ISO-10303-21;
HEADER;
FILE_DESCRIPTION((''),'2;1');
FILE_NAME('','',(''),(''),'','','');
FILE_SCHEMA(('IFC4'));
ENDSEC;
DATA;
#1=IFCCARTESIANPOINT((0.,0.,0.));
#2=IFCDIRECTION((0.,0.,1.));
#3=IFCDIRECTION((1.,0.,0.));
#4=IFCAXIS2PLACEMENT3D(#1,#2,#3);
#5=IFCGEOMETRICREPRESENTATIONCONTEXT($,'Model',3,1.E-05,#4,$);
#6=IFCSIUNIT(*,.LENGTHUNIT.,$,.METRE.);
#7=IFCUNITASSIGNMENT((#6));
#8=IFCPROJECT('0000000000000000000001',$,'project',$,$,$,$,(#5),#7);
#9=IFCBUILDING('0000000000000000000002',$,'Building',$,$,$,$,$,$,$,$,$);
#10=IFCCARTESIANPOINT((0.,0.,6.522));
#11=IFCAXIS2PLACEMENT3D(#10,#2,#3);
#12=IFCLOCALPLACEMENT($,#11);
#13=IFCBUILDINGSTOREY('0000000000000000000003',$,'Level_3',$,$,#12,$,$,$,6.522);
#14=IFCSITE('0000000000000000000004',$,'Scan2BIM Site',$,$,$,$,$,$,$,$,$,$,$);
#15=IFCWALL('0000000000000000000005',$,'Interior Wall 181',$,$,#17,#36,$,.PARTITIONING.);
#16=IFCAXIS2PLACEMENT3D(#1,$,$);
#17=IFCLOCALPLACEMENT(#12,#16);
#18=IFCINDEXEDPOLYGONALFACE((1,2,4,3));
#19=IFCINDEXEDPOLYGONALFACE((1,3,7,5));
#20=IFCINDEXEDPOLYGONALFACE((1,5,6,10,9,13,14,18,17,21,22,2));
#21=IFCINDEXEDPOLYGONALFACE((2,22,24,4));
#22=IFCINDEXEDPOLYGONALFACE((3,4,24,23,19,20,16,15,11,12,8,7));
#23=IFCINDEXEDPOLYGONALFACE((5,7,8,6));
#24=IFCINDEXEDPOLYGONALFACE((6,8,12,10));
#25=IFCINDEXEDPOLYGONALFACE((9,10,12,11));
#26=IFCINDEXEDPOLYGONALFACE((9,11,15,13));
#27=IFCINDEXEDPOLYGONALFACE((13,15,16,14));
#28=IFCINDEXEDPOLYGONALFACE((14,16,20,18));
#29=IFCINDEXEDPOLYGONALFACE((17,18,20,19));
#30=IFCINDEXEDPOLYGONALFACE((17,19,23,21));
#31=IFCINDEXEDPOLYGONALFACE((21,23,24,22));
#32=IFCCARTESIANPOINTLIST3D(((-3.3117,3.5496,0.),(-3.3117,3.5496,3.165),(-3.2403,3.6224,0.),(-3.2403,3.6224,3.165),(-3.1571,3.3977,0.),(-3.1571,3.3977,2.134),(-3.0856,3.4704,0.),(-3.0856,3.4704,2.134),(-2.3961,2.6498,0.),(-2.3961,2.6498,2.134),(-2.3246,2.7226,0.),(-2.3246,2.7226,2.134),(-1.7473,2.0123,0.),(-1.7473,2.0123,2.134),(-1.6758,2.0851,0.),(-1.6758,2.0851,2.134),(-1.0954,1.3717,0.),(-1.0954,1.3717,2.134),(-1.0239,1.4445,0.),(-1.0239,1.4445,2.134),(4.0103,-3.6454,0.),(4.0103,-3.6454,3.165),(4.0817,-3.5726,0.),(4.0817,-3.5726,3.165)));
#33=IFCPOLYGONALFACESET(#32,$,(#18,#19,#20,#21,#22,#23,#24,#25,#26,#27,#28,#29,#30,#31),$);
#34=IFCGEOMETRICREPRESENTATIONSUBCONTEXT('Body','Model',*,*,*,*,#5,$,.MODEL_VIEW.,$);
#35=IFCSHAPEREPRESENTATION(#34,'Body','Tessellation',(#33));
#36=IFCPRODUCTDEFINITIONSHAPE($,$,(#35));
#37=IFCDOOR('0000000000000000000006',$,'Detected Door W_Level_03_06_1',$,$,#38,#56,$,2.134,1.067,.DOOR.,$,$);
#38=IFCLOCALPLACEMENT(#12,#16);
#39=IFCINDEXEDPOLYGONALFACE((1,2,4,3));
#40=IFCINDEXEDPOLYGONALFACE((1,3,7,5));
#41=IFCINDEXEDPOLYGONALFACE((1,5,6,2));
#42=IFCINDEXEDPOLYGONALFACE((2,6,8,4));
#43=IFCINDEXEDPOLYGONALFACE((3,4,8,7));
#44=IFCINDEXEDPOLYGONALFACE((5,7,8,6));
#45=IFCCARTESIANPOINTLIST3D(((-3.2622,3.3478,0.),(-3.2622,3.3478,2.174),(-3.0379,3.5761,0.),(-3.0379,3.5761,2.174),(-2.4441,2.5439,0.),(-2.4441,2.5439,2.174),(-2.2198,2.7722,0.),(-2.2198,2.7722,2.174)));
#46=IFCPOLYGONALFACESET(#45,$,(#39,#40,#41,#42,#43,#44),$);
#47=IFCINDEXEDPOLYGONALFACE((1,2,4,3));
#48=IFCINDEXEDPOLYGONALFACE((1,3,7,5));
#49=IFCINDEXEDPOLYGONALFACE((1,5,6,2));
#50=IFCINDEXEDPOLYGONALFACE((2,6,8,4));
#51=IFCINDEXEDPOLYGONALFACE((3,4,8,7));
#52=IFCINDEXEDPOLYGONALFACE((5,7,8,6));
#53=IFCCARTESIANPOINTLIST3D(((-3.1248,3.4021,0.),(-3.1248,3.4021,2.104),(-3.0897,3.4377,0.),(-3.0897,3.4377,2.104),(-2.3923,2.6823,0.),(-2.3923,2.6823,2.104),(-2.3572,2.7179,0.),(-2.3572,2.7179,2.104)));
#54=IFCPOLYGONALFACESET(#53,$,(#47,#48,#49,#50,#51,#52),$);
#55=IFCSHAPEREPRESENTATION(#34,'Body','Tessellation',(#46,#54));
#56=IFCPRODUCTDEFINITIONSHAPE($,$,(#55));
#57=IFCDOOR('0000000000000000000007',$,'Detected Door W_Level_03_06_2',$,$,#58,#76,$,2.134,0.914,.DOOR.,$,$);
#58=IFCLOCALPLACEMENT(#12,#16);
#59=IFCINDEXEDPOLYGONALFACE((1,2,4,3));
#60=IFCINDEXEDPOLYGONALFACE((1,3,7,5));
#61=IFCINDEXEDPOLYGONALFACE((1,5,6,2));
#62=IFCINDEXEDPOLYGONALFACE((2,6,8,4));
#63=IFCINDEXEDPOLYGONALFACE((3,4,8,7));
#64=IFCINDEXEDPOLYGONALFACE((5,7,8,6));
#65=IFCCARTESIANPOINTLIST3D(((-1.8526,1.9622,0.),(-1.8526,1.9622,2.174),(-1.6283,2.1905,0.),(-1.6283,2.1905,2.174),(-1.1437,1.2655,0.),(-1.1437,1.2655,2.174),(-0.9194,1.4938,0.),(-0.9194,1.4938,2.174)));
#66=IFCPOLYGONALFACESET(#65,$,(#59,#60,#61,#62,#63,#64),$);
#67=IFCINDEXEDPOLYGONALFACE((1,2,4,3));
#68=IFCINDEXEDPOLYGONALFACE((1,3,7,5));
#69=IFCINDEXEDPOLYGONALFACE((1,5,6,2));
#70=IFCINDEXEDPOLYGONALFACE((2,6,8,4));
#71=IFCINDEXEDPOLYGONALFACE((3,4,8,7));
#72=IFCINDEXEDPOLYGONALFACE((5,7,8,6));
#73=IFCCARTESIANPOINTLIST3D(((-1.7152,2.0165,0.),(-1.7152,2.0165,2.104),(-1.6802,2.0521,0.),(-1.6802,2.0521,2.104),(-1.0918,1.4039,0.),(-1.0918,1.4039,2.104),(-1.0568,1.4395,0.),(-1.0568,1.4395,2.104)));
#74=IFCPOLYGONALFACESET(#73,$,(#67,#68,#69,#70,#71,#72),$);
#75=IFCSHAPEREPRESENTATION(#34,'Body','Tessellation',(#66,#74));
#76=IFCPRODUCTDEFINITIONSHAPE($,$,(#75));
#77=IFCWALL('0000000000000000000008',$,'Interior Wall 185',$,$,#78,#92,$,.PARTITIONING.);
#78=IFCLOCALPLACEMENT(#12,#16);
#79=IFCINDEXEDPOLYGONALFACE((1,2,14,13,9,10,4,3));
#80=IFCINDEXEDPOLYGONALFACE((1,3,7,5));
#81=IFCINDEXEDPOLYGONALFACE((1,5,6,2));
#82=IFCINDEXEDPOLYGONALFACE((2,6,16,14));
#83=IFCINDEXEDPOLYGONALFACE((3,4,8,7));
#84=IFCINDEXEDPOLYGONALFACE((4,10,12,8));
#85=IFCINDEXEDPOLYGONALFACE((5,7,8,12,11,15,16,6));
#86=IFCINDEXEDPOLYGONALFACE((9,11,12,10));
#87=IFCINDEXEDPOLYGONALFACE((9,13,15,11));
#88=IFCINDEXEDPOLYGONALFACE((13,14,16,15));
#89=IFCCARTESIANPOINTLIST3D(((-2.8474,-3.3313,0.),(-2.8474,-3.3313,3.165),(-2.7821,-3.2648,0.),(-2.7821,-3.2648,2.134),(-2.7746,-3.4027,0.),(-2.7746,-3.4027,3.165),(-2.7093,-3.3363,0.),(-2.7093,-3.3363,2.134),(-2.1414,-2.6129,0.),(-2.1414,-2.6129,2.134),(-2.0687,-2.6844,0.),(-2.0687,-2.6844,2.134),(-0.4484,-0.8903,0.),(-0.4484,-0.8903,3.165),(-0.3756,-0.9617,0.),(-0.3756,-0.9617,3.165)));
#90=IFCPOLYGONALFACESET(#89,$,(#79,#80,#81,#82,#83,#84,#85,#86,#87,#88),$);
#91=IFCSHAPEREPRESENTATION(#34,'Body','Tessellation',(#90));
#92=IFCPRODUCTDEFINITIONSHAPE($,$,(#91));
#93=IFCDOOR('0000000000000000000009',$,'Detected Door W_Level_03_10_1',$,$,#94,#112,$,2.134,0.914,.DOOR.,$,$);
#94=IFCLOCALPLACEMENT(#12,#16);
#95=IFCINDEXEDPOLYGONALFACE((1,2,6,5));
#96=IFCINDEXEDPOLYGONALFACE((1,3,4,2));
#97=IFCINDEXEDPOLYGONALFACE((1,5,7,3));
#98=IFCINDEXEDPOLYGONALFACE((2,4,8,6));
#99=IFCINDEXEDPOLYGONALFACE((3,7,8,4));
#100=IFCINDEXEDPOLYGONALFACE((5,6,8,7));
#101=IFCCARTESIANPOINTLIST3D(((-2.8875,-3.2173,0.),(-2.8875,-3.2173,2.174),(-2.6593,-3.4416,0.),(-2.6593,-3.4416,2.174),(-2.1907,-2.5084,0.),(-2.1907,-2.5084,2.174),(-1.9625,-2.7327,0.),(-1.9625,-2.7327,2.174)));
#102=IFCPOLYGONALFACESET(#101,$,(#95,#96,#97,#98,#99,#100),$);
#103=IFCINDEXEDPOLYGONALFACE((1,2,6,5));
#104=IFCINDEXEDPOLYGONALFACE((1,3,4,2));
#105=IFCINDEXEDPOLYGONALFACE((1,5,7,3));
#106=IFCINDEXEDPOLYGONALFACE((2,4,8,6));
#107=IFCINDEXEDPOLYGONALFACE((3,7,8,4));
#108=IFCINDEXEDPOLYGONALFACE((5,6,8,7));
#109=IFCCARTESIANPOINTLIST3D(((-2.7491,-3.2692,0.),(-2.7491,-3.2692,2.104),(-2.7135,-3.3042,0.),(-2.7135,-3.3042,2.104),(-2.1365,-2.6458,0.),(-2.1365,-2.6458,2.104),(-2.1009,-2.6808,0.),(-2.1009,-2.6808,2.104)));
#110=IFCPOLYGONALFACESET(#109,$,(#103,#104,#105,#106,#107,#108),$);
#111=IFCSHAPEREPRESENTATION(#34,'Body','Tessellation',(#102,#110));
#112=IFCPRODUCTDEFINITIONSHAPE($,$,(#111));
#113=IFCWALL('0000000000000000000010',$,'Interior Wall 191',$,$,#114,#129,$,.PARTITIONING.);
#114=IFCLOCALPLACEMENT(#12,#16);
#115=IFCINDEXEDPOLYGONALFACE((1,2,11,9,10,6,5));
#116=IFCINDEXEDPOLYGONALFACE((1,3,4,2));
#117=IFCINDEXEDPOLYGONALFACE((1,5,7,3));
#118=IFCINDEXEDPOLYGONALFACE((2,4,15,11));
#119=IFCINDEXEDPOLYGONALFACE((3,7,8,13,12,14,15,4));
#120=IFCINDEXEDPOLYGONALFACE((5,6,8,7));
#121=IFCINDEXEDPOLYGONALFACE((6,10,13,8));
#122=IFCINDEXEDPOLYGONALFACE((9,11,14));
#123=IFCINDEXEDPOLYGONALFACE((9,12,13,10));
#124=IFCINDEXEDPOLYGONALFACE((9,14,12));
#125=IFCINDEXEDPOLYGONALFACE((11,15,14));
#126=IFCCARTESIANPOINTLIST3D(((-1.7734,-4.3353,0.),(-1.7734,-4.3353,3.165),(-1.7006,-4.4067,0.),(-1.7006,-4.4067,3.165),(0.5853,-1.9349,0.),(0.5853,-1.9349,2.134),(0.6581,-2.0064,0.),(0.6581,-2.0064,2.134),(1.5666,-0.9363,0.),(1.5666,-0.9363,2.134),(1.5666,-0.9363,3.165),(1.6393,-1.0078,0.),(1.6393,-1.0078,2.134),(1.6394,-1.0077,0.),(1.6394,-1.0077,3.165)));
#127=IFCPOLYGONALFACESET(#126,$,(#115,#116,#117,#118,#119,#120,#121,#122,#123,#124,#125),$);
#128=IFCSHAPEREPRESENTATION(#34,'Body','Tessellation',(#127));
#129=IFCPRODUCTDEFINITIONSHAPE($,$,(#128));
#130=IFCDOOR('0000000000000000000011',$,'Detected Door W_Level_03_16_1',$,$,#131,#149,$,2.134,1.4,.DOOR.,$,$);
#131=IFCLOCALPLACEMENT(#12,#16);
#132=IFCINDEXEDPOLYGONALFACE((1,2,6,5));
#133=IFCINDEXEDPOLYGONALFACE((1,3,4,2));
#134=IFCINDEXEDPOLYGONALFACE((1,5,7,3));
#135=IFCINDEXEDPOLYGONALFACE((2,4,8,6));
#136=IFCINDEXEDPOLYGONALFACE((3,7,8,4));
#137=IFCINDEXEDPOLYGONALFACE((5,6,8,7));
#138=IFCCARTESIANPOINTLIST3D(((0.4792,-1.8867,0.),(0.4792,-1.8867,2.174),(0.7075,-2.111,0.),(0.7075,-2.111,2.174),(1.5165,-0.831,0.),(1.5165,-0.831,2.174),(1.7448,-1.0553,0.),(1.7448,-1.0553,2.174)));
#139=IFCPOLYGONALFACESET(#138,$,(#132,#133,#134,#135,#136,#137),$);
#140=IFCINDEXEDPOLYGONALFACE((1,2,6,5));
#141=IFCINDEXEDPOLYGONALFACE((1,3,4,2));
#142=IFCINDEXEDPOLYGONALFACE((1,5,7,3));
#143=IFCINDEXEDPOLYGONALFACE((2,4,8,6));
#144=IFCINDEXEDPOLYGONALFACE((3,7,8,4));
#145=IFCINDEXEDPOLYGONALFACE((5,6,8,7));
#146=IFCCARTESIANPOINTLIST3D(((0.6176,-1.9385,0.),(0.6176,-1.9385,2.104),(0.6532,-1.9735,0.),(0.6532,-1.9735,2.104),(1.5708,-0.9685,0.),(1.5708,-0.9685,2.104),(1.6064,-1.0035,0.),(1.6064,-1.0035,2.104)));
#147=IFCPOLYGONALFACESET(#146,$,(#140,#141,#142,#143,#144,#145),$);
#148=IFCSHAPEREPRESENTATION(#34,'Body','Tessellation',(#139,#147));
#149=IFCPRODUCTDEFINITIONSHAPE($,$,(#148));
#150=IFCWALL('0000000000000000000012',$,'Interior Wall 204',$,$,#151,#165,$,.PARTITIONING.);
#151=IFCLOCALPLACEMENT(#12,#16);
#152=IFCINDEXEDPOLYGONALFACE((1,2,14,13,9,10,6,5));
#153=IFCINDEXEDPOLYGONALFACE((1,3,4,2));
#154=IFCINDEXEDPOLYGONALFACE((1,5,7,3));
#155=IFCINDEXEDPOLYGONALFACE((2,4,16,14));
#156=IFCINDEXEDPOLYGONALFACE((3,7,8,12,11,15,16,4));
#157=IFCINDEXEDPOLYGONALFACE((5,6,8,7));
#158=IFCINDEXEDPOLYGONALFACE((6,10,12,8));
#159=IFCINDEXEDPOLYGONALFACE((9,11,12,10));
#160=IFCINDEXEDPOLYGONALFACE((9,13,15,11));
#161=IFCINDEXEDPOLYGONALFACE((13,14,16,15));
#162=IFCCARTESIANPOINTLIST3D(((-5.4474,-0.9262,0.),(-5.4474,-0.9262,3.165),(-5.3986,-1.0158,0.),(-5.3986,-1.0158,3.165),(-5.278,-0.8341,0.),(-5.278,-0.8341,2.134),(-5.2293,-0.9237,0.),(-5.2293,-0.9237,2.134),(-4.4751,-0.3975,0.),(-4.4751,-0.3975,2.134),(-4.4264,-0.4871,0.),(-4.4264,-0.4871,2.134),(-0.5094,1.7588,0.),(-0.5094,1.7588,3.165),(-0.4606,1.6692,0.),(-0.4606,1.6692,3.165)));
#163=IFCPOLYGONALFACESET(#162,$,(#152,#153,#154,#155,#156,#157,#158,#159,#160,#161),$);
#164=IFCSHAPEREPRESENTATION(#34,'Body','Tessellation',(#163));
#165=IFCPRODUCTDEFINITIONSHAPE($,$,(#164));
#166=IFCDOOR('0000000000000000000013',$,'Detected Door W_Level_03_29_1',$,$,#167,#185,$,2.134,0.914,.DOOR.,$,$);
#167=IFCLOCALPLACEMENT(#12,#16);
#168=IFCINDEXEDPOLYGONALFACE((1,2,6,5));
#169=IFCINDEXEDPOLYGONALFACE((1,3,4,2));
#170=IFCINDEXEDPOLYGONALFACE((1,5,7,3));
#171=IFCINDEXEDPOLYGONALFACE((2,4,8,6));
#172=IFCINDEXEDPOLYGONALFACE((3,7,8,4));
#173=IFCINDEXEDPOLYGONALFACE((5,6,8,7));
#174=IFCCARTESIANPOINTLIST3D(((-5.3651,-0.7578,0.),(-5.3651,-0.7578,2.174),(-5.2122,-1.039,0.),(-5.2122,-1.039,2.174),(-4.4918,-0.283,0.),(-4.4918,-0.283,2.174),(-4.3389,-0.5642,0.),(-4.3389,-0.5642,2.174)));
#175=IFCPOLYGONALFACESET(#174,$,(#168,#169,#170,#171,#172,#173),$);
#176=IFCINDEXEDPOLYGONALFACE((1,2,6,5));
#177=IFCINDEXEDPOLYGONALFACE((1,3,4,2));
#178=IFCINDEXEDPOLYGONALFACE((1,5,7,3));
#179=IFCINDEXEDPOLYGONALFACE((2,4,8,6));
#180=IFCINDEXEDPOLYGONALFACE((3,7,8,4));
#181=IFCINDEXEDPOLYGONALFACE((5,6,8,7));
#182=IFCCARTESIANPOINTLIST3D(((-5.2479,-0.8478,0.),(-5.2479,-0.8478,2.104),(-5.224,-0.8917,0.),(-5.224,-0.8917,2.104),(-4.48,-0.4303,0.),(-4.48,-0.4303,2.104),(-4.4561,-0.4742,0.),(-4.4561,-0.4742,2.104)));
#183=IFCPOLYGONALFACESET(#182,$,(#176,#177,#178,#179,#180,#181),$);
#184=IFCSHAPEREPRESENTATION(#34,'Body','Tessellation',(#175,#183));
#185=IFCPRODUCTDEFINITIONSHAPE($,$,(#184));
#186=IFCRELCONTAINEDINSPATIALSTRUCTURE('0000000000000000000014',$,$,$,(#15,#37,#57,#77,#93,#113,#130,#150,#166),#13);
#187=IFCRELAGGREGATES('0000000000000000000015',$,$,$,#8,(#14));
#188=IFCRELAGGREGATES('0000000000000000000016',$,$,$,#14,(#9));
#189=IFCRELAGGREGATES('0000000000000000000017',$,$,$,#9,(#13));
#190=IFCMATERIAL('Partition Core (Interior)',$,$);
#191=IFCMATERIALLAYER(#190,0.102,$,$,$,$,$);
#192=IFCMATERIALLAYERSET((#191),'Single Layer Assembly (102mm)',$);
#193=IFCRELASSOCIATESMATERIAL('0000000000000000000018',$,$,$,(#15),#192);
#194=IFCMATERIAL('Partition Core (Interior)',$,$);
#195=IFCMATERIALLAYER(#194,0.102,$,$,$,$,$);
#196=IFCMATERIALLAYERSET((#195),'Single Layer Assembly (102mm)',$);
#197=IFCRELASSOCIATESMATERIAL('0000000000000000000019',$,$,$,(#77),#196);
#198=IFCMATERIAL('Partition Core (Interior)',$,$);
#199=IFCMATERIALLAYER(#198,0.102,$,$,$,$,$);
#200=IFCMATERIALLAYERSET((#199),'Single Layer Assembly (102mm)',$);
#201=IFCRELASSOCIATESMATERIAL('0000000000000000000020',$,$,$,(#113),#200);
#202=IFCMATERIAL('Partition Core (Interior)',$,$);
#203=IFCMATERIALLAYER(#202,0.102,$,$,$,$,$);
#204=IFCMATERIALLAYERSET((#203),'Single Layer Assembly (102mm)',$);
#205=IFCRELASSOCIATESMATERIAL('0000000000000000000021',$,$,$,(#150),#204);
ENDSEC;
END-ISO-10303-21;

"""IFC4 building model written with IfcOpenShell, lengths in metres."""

from ifc_helpers import new_model, si_unit, frame, origin, origin_with_axes, place, context, subcontext, project, spatial, rectangle, extrude, material, layer, layer_set, element, fill, save


model = new_model("IFC4")

# Units and contexts
model_context = context("Model", 3, precision=1e-05, world=origin_with_axes())
body_context = subcontext(model_context, "Body", "Model", "MODEL_VIEW")
ifc_project = project(units=[si_unit("LENGTHUNIT", "METRE")], contexts=[model_context])

# Site, building, storey
site = spatial("IfcSite", under=ifc_project, Name="Scan2BIM Site")
building = spatial("IfcBuilding", under=site, Name="Building")
storey_placement = place(None, frame((0.0, 0.0, 6.522), z_axis=(0.0, 0.0, 1.0), x_axis=(1.0, 0.0, 0.0)))
storey = spatial("IfcBuildingStorey", under=building, at=storey_placement, Name="Level_3", Elevation=6.522)

# Wall, openings, doors
ifc_material_1 = material(Name="Partition Core (Interior)")
ifc_layer_1 = layer(ifc_material_1, 0.102)
ifc_layer_set_1 = layer_set([ifc_layer_1], Name="Single Layer Assembly (102mm)")
wall_1_placement = place(storey_placement, frame((0.385, -0.0115, 0.0), z_axis=(0.0, 0.0, 1.0), x_axis=(0.713266, -0.700894, 0.0)))
wall_1 = element("IfcWall", 1, at=wall_1_placement, inside=storey, material=ifc_layer_set_1, Name="Interior Wall 181", PredefinedType="PARTITIONING", context=body_context, shape_type="SweptSolid", body=[
    extrude(rectangle(XDim=10.2655, YDim=0.102), origin(), (0.0, 0.0, 1.0), 3.165),
])
opening_1_placement = place(None, frame((-2.741, 3.06, 6.522), z_axis=(0.0, 0.0, 1.0), x_axis=(0.713266, -0.700894, 0.0)))
opening_1 = element("IfcOpeningElement", 2, at=opening_1_placement, cuts=wall_1, PredefinedType="OPENING", context=body_context, shape_type="SweptSolid", body=[
    extrude(rectangle(XDim=1.067, YDim=0.202), origin(), (0.0, 0.0, 1.0), 2.134),
])
opening_2_placement = place(None, frame((-1.386, 1.728, 6.522), z_axis=(0.0, 0.0, 1.0), x_axis=(0.713266, -0.700894, 0.0)))
opening_2 = element("IfcOpeningElement", 3, at=opening_2_placement, cuts=wall_1, PredefinedType="OPENING", context=body_context, shape_type="SweptSolid", body=[
    extrude(rectangle(XDim=0.914, YDim=0.202), origin(), (0.0, 0.0, 1.0), 2.134),
])
door_1_placement = place(opening_1_placement, frame((0.0, 0.0, 0.0), z_axis=(0.0, 0.0, 1.0), x_axis=(1.0, 0.0, 0.0)))
door_1 = element("IfcDoor", 4, at=door_1_placement, inside=storey, Name="Detected Door W_Level_03_06_1", OverallHeight=2.134, OverallWidth=1.067, PredefinedType="DOOR", context=body_context, shape_type="SweptSolid", body=[
    extrude(rectangle(XDim=1.147, YDim=0.32), origin(), (0.0, 0.0, 1.0), 2.174),
    extrude(rectangle(XDim=1.027, YDim=0.05), origin(), (0.0, 0.0, 1.0), 2.104),
])
fill(opening_1, door_1)
door_2_placement = place(opening_2_placement, frame((0.0, 0.0, 0.0), z_axis=(0.0, 0.0, 1.0), x_axis=(1.0, 0.0, 0.0)))
door_2 = element("IfcDoor", 5, at=door_2_placement, inside=storey, Name="Detected Door W_Level_03_06_2", OverallHeight=2.134, OverallWidth=0.914, PredefinedType="DOOR", context=body_context, shape_type="SweptSolid", body=[
    extrude(rectangle(XDim=0.994, YDim=0.32), origin(), (0.0, 0.0, 1.0), 2.174),
    extrude(rectangle(XDim=0.874, YDim=0.05), origin(), (0.0, 0.0, 1.0), 2.104),
])
fill(opening_2, door_2)

# Walls, openings, doors
ifc_material_2 = material(Name="Partition Core (Interior)")
ifc_layer_2 = layer(ifc_material_2, 0.102)
ifc_layer_set_2 = layer_set([ifc_layer_2], Name="Single Layer Assembly (102mm)")
wall_2_placement = place(storey_placement, frame((-1.6115, -2.1465, 0.0), z_axis=(0.0, 0.0, 1.0), x_axis=(0.700944, 0.713216, 0.0)))
wall_2 = element("IfcWall", 6, at=wall_2_placement, inside=storey, material=ifc_layer_set_2, Name="Interior Wall 185", PredefinedType="PARTITIONING", context=body_context, shape_type="SweptSolid", body=[
    extrude(rectangle(XDim=3.4225, YDim=0.102), origin(), (0.0, 0.0, 1.0), 3.165),
])
opening_3_placement = place(None, frame((-2.425, -2.975, 6.522), z_axis=(0.0, 0.0, 1.0), x_axis=(0.700944, 0.713216, 0.0)))
opening_3 = element("IfcOpeningElement", 7, at=opening_3_placement, cuts=wall_2, PredefinedType="OPENING", context=body_context, shape_type="SweptSolid", body=[
    extrude(rectangle(XDim=0.914, YDim=0.202), origin(), (0.0, 0.0, 1.0), 2.134),
])
door_3_placement = place(opening_3_placement, frame((0.0, 0.0, 0.0), z_axis=(0.0, 0.0, 1.0), x_axis=(1.0, 0.0, 0.0)))
door_3 = element("IfcDoor", 8, at=door_3_placement, inside=storey, Name="Detected Door W_Level_03_10_1", OverallHeight=2.134, OverallWidth=0.914, PredefinedType="DOOR", context=body_context, shape_type="SweptSolid", body=[
    extrude(rectangle(XDim=0.994, YDim=0.32), origin(), (0.0, 0.0, 1.0), 2.174),
    extrude(rectangle(XDim=0.874, YDim=0.05), origin(), (0.0, 0.0, 1.0), 2.104),
])
fill(opening_3, door_3)
ifc_material_3 = material(Name="Partition Core (Interior)")
ifc_layer_3 = layer(ifc_material_3, 0.102)
ifc_layer_set_3 = layer_set([ifc_layer_3], Name="Single Layer Assembly (102mm)")
wall_3_placement = place(storey_placement, frame((-0.067, -2.6715, 0.0), z_axis=(0.0, 0.0, 1.0), x_axis=(-0.700889, -0.71327, 0.0)))
wall_3 = element("IfcWall", 9, at=wall_3_placement, inside=storey, material=ifc_layer_set_3, Name="Interior Wall 191", PredefinedType="PARTITIONING", context=body_context, shape_type="SweptSolid", body=[
    extrude(rectangle(XDim=4.7654, YDim=0.102), origin(), (0.0, 0.0, 1.0), 3.165),
])
opening_4_placement = place(None, frame((1.112, -1.471, 6.522), z_axis=(0.0, 0.0, 1.0), x_axis=(-0.700889, -0.71327, 0.0)))
opening_4 = element("IfcOpeningElement", 10, at=opening_4_placement, cuts=wall_3, PredefinedType="OPENING", context=body_context, shape_type="SweptSolid", body=[
    extrude(rectangle(XDim=1.4, YDim=0.202), origin(), (0.0, 0.0, 1.0), 2.134),
])
door_4_placement = place(opening_4_placement, frame((0.0, 0.0, 0.0), z_axis=(0.0, 0.0, 1.0), x_axis=(1.0, 0.0, 0.0)))
door_4 = element("IfcDoor", 11, at=door_4_placement, inside=storey, Name="Detected Door W_Level_03_16_1", OverallHeight=2.134, OverallWidth=1.4, PredefinedType="DOOR", context=body_context, shape_type="SweptSolid", body=[
    extrude(rectangle(XDim=1.48, YDim=0.32), origin(), (0.0, 0.0, 1.0), 2.174),
    extrude(rectangle(XDim=1.36, YDim=0.05), origin(), (0.0, 0.0, 1.0), 2.104),
])
fill(opening_4, door_4)
ifc_material_4 = material(Name="Partition Core (Interior)")
ifc_layer_4 = layer(ifc_material_4, 0.102)
ifc_layer_set_4 = layer_set([ifc_layer_4], Name="Single Layer Assembly (102mm)")
wall_4_placement = place(storey_placement, frame((-2.954, 0.3715, 0.0), z_axis=(0.0, 0.0, 1.0), x_axis=(0.878527, 0.477692, 0.0)))
wall_4 = element("IfcWall", 12, at=wall_4_placement, inside=storey, material=ifc_layer_set_4, Name="Interior Wall 204", PredefinedType="PARTITIONING", context=body_context, shape_type="SweptSolid", body=[
    extrude(rectangle(XDim=5.6208, YDim=0.102), origin(), (0.0, 0.0, 1.0), 3.165),
])
opening_5_placement = place(None, frame((-4.852, -0.661, 6.522), z_axis=(0.0, 0.0, 1.0), x_axis=(0.878527, 0.477692, 0.0)))
opening_5 = element("IfcOpeningElement", 13, at=opening_5_placement, cuts=wall_4, PredefinedType="OPENING", context=body_context, shape_type="SweptSolid", body=[
    extrude(rectangle(XDim=0.914, YDim=0.202), origin(), (0.0, 0.0, 1.0), 2.134),
])
door_5_placement = place(opening_5_placement, frame((0.0, 0.0, 0.0), z_axis=(0.0, 0.0, 1.0), x_axis=(1.0, 0.0, 0.0)))
door_5 = element("IfcDoor", 14, at=door_5_placement, inside=storey, Name="Detected Door W_Level_03_29_1", OverallHeight=2.134, OverallWidth=0.914, PredefinedType="DOOR", context=body_context, shape_type="SweptSolid", body=[
    extrude(rectangle(XDim=0.994, YDim=0.32), origin(), (0.0, 0.0, 1.0), 2.174),
    extrude(rectangle(XDim=0.874, YDim=0.05), origin(), (0.0, 0.0, 1.0), 2.104),
])
fill(opening_5, door_5)

save(model, "model.ifc")
